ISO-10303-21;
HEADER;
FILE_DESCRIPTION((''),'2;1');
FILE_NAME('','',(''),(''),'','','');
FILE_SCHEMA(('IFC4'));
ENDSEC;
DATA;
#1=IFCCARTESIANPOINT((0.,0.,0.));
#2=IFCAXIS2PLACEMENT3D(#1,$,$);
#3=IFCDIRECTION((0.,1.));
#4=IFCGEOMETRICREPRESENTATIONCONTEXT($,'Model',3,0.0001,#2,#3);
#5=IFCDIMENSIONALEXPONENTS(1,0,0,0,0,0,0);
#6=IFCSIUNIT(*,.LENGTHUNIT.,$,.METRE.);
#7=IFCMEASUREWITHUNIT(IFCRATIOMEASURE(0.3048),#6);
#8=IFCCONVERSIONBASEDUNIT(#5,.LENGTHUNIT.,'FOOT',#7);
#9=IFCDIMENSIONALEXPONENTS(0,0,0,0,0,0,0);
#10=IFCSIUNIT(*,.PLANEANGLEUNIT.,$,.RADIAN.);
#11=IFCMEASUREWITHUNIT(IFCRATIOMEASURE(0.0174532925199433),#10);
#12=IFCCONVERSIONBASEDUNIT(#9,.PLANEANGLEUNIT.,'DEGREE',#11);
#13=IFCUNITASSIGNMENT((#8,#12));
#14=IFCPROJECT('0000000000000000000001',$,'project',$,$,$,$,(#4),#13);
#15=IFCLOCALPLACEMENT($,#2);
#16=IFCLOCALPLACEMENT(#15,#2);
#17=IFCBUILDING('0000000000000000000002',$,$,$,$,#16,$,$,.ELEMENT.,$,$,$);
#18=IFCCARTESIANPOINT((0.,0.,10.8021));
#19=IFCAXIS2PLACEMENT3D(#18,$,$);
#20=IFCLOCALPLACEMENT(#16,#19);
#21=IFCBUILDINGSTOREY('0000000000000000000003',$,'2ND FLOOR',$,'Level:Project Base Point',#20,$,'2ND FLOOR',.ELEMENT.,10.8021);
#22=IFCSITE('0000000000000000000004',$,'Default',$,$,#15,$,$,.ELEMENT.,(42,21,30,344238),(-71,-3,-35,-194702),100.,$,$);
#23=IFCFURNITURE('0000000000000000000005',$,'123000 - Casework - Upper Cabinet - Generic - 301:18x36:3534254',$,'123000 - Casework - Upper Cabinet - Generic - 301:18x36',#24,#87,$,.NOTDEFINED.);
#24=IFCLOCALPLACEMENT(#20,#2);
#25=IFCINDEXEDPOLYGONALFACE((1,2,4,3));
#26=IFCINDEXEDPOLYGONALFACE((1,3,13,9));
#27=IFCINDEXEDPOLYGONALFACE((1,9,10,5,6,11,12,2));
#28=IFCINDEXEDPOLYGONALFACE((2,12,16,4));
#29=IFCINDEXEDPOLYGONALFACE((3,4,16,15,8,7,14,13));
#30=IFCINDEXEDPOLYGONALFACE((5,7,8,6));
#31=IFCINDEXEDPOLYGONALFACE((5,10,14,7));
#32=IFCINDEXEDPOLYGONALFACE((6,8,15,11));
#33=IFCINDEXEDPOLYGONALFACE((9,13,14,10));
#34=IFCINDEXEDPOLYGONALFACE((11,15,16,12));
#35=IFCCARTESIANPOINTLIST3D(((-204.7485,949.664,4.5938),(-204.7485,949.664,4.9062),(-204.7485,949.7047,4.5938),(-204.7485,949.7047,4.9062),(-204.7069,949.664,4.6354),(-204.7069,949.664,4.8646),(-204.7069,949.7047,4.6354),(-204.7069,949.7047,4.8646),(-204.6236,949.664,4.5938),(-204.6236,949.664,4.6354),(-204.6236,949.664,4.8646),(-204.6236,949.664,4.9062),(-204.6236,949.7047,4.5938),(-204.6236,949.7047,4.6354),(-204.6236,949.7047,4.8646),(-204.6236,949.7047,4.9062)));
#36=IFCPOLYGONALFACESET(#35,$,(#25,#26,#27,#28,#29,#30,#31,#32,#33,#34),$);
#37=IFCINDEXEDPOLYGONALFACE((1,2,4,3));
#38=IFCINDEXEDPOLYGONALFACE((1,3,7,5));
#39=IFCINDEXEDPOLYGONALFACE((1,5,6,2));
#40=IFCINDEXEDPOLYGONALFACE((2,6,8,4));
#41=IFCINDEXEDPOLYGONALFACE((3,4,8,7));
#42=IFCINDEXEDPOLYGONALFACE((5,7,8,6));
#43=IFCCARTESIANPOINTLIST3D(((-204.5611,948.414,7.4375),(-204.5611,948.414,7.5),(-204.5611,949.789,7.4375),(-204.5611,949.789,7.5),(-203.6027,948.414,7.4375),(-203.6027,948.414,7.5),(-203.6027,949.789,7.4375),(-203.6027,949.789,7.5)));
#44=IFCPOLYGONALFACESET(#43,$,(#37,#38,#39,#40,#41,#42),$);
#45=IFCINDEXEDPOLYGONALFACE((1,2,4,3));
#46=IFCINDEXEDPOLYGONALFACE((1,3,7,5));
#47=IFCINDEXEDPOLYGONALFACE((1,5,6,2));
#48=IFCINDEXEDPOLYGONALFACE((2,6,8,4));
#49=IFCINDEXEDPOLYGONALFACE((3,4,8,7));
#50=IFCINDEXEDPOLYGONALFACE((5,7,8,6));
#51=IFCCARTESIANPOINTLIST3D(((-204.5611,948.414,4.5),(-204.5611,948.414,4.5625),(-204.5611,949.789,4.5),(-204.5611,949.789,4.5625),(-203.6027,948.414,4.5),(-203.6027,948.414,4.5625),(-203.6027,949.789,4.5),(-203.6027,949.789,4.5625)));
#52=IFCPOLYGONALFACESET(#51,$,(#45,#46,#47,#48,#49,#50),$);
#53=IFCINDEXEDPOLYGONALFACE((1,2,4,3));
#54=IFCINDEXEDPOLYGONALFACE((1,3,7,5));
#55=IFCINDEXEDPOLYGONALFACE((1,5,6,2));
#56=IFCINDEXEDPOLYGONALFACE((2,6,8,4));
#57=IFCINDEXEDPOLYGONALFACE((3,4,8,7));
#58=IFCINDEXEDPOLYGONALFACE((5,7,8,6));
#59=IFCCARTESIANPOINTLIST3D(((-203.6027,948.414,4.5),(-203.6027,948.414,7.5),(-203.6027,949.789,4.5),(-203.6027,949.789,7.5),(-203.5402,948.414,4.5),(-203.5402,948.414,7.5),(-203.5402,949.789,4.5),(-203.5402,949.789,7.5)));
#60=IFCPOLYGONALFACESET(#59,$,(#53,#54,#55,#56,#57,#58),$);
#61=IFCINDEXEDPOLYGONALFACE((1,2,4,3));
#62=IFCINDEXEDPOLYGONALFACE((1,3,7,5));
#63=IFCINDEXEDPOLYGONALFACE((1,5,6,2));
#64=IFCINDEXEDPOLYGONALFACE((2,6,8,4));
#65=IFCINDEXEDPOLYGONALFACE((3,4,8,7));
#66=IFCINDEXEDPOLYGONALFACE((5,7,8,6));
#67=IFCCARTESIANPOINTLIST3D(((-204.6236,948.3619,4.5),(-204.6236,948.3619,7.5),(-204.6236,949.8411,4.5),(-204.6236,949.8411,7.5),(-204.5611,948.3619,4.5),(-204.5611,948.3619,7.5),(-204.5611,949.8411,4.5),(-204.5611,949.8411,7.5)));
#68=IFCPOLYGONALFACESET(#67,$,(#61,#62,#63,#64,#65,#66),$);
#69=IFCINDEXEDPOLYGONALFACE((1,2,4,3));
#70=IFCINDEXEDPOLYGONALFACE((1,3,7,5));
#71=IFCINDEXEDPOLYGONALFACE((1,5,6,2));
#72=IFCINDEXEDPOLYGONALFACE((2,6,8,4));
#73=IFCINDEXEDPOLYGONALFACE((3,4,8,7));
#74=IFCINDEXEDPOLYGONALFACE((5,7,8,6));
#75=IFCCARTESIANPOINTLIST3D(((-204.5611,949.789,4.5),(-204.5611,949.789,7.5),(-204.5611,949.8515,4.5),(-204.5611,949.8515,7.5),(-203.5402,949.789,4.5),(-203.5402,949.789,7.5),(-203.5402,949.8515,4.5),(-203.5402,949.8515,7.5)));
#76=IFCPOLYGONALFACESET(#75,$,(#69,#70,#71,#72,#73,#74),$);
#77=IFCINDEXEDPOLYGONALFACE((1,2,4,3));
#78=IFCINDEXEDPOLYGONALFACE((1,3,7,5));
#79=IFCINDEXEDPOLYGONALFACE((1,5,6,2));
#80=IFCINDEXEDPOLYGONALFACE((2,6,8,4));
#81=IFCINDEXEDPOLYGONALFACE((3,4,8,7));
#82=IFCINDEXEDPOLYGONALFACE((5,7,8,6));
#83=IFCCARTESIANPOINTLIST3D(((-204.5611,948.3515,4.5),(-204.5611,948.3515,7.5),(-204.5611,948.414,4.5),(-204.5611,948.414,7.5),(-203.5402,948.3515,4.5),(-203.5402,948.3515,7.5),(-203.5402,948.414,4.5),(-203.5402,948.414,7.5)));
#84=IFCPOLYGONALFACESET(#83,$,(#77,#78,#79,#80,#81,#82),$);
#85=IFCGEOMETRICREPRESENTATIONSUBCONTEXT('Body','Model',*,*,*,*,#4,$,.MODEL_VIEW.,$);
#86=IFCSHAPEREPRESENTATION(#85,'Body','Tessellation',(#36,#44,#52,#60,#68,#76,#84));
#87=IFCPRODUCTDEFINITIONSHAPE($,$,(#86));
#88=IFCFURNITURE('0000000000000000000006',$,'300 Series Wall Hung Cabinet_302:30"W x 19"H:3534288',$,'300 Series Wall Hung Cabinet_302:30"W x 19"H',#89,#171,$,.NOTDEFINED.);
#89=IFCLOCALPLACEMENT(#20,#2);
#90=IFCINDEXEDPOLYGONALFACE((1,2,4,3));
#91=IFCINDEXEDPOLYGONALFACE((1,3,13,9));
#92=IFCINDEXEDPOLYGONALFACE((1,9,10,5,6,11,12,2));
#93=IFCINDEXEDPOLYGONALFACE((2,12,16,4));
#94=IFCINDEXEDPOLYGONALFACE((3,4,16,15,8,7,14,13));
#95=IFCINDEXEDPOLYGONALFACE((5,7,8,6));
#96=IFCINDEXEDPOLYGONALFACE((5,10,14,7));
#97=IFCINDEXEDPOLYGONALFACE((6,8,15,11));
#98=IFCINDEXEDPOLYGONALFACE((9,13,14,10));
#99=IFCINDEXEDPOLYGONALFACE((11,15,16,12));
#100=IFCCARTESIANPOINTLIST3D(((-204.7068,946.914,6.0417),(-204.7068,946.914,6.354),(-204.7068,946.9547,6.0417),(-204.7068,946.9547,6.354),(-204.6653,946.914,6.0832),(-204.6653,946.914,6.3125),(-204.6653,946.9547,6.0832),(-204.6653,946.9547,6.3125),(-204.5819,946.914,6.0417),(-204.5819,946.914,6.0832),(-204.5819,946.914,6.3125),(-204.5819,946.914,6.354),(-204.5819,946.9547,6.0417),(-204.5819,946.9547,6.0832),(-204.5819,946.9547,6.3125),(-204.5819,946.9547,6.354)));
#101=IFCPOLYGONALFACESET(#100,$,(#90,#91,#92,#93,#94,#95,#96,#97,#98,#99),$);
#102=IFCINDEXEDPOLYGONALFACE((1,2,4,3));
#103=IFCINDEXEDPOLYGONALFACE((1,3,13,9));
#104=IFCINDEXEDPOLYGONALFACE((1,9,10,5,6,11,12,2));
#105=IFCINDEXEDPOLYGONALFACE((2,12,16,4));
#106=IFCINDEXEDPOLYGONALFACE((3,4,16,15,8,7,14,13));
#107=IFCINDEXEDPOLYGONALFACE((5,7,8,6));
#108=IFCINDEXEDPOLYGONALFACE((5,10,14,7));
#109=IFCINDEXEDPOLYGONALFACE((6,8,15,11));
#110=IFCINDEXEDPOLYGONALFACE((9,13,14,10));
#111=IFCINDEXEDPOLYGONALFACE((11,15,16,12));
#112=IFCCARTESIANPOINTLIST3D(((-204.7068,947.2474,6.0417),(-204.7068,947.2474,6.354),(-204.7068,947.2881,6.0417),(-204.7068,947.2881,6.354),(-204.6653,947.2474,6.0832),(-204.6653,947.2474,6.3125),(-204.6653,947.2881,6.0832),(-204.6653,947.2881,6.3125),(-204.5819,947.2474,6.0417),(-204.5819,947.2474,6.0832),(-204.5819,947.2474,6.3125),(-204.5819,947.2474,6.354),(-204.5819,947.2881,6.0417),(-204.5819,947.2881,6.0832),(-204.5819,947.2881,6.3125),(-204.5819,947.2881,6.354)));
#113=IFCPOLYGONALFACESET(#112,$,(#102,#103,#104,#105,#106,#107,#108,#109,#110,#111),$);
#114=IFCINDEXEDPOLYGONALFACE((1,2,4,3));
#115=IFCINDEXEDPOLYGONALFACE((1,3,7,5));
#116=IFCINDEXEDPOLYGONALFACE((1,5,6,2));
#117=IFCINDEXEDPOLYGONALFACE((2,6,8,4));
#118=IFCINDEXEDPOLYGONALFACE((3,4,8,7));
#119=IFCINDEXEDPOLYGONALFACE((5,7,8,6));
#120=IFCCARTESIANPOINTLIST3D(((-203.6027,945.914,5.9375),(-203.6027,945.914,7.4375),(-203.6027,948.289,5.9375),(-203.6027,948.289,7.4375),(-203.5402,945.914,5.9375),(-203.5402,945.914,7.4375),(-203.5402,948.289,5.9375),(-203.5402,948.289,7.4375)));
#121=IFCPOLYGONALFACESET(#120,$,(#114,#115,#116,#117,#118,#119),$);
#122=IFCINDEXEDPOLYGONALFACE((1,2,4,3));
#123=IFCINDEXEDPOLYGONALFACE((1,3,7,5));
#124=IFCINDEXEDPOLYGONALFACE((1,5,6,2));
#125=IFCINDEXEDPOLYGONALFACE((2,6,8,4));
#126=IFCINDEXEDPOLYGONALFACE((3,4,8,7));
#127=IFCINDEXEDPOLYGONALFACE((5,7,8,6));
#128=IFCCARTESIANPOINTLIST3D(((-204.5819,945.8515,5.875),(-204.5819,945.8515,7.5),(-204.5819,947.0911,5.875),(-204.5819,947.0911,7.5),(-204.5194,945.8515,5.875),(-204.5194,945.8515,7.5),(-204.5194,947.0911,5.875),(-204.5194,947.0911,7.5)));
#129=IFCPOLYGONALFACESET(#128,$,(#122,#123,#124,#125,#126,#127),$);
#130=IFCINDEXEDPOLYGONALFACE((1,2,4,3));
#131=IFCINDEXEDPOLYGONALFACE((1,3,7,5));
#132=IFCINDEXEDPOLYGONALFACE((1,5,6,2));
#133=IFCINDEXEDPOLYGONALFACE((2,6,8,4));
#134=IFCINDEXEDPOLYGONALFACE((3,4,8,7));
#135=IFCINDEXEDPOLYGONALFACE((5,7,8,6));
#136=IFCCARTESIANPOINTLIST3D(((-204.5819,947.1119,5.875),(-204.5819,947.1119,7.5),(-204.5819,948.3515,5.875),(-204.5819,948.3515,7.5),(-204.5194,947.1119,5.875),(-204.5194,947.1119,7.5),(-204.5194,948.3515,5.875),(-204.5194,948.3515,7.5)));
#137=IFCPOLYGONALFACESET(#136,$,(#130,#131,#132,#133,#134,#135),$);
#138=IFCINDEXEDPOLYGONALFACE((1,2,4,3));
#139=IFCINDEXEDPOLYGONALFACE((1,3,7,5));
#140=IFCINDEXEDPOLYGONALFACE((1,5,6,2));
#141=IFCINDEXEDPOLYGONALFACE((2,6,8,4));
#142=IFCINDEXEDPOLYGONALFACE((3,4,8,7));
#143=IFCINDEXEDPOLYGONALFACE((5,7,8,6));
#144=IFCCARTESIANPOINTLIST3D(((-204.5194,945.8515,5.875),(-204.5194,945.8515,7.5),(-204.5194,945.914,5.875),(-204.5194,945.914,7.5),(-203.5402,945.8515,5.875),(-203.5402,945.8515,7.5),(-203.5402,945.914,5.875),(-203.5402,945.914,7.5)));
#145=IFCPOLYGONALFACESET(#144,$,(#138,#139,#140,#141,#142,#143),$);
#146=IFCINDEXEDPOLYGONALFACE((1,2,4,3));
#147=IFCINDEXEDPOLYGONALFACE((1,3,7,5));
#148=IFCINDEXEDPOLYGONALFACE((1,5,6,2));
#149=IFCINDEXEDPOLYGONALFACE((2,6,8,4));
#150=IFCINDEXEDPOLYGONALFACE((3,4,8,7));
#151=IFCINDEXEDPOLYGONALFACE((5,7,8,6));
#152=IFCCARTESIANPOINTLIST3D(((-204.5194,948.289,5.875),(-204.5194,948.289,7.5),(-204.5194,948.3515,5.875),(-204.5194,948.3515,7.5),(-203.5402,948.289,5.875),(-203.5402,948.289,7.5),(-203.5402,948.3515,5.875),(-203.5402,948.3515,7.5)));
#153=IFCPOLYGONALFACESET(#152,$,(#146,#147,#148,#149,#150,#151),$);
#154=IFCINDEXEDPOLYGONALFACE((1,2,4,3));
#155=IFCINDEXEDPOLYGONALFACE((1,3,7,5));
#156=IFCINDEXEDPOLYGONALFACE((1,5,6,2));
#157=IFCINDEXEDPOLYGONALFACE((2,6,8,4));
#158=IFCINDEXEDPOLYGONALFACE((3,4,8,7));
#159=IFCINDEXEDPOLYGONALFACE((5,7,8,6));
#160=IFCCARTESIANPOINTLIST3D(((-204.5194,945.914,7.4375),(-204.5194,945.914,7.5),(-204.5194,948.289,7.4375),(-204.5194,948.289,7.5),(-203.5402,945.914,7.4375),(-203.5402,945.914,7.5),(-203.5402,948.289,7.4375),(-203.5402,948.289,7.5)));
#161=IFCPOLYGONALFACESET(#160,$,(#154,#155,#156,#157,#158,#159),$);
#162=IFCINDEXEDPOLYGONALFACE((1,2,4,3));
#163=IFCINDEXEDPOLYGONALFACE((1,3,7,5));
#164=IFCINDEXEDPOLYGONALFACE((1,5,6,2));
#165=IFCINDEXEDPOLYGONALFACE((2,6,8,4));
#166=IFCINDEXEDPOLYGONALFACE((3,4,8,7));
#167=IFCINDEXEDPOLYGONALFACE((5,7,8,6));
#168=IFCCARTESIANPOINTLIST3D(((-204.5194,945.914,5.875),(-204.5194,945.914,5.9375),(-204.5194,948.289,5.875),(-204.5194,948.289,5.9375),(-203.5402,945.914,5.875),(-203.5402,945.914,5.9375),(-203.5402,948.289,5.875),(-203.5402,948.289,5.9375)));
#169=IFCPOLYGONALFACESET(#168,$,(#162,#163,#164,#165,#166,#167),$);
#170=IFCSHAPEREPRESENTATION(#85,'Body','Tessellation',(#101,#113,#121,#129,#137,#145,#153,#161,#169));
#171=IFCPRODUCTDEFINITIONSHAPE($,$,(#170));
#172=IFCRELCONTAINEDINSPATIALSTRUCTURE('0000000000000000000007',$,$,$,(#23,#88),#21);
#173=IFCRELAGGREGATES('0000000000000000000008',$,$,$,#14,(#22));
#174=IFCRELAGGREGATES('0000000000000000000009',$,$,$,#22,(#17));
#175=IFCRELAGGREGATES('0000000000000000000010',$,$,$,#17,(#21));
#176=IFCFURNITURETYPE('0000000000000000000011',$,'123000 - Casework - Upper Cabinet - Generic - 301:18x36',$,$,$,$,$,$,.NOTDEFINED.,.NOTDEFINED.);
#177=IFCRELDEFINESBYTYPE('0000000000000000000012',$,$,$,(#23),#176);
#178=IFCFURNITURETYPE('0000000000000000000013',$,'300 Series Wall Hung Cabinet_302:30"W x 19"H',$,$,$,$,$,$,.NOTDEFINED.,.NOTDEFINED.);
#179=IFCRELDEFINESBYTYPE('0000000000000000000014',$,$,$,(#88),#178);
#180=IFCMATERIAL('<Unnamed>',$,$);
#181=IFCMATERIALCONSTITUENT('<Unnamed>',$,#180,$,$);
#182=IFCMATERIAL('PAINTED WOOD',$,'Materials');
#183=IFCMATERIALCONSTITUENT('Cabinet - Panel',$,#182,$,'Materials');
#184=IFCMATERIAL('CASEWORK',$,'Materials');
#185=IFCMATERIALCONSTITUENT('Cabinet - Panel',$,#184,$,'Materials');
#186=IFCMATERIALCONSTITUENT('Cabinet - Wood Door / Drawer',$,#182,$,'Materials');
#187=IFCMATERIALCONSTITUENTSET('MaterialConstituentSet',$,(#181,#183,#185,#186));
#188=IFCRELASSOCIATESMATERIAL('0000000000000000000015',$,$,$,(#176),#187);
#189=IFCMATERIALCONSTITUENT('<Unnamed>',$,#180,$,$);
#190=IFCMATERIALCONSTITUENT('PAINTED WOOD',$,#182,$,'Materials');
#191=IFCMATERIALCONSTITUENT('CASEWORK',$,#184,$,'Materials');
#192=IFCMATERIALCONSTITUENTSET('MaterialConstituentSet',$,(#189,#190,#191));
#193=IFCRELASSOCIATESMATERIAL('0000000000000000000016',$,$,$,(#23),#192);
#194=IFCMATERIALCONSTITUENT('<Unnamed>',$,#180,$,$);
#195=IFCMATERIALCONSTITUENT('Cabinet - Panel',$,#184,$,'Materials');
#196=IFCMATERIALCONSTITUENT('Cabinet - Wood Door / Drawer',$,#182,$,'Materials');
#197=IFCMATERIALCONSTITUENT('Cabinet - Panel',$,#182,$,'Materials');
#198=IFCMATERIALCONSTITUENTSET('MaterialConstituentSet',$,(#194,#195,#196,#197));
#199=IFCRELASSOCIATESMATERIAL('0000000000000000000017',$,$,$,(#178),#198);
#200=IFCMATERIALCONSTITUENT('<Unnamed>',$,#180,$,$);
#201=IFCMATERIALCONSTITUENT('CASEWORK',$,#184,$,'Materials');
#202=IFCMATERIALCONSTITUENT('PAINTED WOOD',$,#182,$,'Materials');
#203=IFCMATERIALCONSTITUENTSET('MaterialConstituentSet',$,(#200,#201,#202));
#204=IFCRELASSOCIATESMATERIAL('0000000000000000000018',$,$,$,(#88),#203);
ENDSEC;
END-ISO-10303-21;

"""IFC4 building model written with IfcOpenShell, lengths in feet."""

from ifc_helpers import new_model, entity, si_unit, converted_unit, direction, frame, frame_2d, origin, origin_2d_with_axis, place, context, subcontext, project, spatial, polyline, rectangle, outline, extrude, source, transform, mapped, material, constituent, constituent_set, type_object, type_shapes, element, save


model = new_model("IFC4")

# Units and contexts
model_context = context("Model", 3, precision=0.0001, world=origin(), true_north=direction((0.0, 1.0)))
body_context = subcontext(model_context, "Body", "Model", "MODEL_VIEW")
ifc_project = project(units=[converted_unit("LENGTHUNIT", "FOOT", entity("IfcRatioMeasure", 0.3048), si_unit("LENGTHUNIT", "METRE"), dimensions=[1, 0, 0, 0, 0, 0, 0]), converted_unit("PLANEANGLEUNIT", "DEGREE", entity("IfcRatioMeasure", 0.0174532925199433), si_unit("PLANEANGLEUNIT", "RADIAN"), dimensions=[0, 0, 0, 0, 0, 0, 0])], contexts=[model_context])

# Site, building, storey
site_placement = place(None, origin())
site = spatial("IfcSite", under=ifc_project, at=site_placement, Name="Default", CompositionType="ELEMENT", RefLatitude=(42, 21, 30, 344238), RefLongitude=(-71, -3, -35, -194702), RefElevation=100.0)
building_placement = place(site_placement, origin())
building = spatial("IfcBuilding", under=site, at=building_placement, CompositionType="ELEMENT")
storey_placement = place(building_placement, frame((0.0, 0.0, 10.8021)))
storey = spatial("IfcBuildingStorey", under=building, at=storey_placement, Name="2ND FLOOR", ObjectType="Level:Project Base Point", LongName="2ND FLOOR", CompositionType="ELEMENT", Elevation=10.8021)

# Furniture
ifc_material_1 = material(Name="CASEWORK", Category="Materials")
ifc_material_2 = material(Name="<Unnamed>")
ifc_material_3 = material(Name="PAINTED WOOD", Category="Materials")
ifc_constituent_1 = constituent(ifc_material_2, Name="<Unnamed>")
ifc_constituent_2 = constituent(ifc_material_3, Name="PAINTED WOOD", Category="Materials")
ifc_constituent_3 = constituent(ifc_material_1, Name="CASEWORK", Category="Materials")
ifc_constituent_set_1 = constituent_set(constituents=[ifc_constituent_1, ifc_constituent_2, ifc_constituent_3], Name="MaterialConstituentSet")
ifc_constituent_4 = constituent(ifc_material_2, Name="<Unnamed>")
ifc_constituent_5 = constituent(ifc_material_3, Name="Cabinet - Panel", Category="Materials")
ifc_constituent_6 = constituent(ifc_material_1, Name="Cabinet - Panel", Category="Materials")
ifc_constituent_7 = constituent(ifc_material_3, Name="Cabinet - Wood Door / Drawer", Category="Materials")
ifc_constituent_set_2 = constituent_set(constituents=[ifc_constituent_4, ifc_constituent_5, ifc_constituent_6, ifc_constituent_7], Name="MaterialConstituentSet")
furniture_type_1 = type_object("IfcFurnitureType", Name="123000 - Casework - Upper Cabinet - Generic - 301:18x36", AssemblyPlace="NOTDEFINED", PredefinedType="NOTDEFINED", material=ifc_constituent_set_2)
shared_shape_1 = source(origin(), body_context, "Body", "SweptSolid", [
    extrude(outline(polyline([(0.1146, -0.0521), (0.1562, -0.0521), (0.1562, 0.0729), (-0.1562, 0.0729), (-0.1562, -0.0521), (-0.1146, -0.0521), (-0.1146, 0.0313), (0.1146, 0.0313), (0.1146, -0.0521)])), frame((0.1468, 0.0729, 0.25), z_axis=(1.0, 0.0, 0.0), x_axis=(0.0, 0.0, 1.0)), (0.0, 0.0, 1.0), 0.0407),
    extrude(rectangle(XDim=1.375, YDim=0.9583, at=frame_2d((0.0, 0.0), x_axis=(1.0, 0.0))), frame((0.75, 0.6666, 2.9375), z_axis=(0.0, 0.0, 1.0), x_axis=(-1.0, 0.0, 0.0)), (0.0, 0.0, 1.0), 0.0625),
    extrude(rectangle(XDim=1.375, YDim=0.9583, at=frame_2d((0.0, 0.0), x_axis=(1.0, 0.0))), frame((0.75, 0.6666, 0.0), z_axis=(0.0, 0.0, 1.0), x_axis=(-1.0, 0.0, 0.0)), (0.0, 0.0, 1.0), 0.0625),
    extrude(rectangle(XDim=0.0625, YDim=1.375, at=origin_2d_with_axis()), frame((0.75, 1.177, 0.0), z_axis=(0.0, 0.0, 1.0), x_axis=(0.0, 1.0, 0.0)), (0.0, 0.0, 1.0), 3.0),
    extrude(rectangle(XDim=0.0625, YDim=1.4792, at=origin_2d_with_axis()), frame((0.75, 0.1562, 0.0), z_axis=(0.0, 0.0, 1.0), x_axis=(0.0, -1.0, 0.0)), (0.0, 0.0, 1.0), 3.0),
    extrude(rectangle(XDim=0.0625, YDim=1.0208, at=origin_2d_with_axis()), frame((0.0312, 0.6979, 0.0), z_axis=(0.0, 0.0, 1.0), x_axis=(-1.0, 0.0, 0.0)), (0.0, 0.0, 1.0), 3.0),
    extrude(rectangle(XDim=0.0625, YDim=1.0208, at=origin_2d_with_axis()), frame((1.4688, 0.6979, 0.0), z_axis=(0.0, 0.0, 1.0), x_axis=(-1.0, 0.0, 0.0)), (0.0, 0.0, 1.0), 3.0),
])
type_shapes(furniture_type_1, [shared_shape_1])
furniture_1_placement = place(storey_placement, frame((-204.7485, 949.8515, 4.5), z_axis=(0.0, 0.0, 1.0), x_axis=(0.0, -1.0, 0.0)))
element("IfcFurniture", 1, at=furniture_1_placement, inside=storey, type_object=furniture_type_1, material=ifc_constituent_set_1, Name="123000 - Casework - Upper Cabinet - Generic - 301:18x36:3534254", ObjectType="123000 - Casework - Upper Cabinet - Generic - 301:18x36", PredefinedType="NOTDEFINED", context=body_context, shape_type="MappedRepresentation", body=[
    mapped(shared_shape_1, transform((0.0, 0.0, 0.0), scale=1.0)),
])
ifc_constituent_8 = constituent(ifc_material_2, Name="<Unnamed>")
ifc_constituent_9 = constituent(ifc_material_1, Name="CASEWORK", Category="Materials")
ifc_constituent_10 = constituent(ifc_material_3, Name="PAINTED WOOD", Category="Materials")
ifc_constituent_set_3 = constituent_set(constituents=[ifc_constituent_8, ifc_constituent_9, ifc_constituent_10], Name="MaterialConstituentSet")
ifc_constituent_11 = constituent(ifc_material_2, Name="<Unnamed>")
ifc_constituent_12 = constituent(ifc_material_1, Name="Cabinet - Panel", Category="Materials")
ifc_constituent_13 = constituent(ifc_material_3, Name="Cabinet - Wood Door / Drawer", Category="Materials")
ifc_constituent_14 = constituent(ifc_material_3, Name="Cabinet - Panel", Category="Materials")
ifc_constituent_set_4 = constituent_set(constituents=[ifc_constituent_11, ifc_constituent_12, ifc_constituent_13, ifc_constituent_14], Name="MaterialConstituentSet")
furniture_type_2 = type_object("IfcFurnitureType", Name="300 Series Wall Hung Cabinet_302:30\"W x 19\"H", AssemblyPlace="NOTDEFINED", PredefinedType="NOTDEFINED", material=ifc_constituent_set_4)
shared_shape_2 = source(origin(), body_context, "Body", "SweptSolid", [
    extrude(outline(polyline([(-0.0521, -0.1146), (-0.0521, -0.1562), (0.0729, -0.1562), (0.0729, 0.1562), (-0.0521, 0.1562), (-0.0521, 0.1146), (0.0313, 0.1146), (0.0313, -0.1146), (-0.0521, -0.1146)])), frame((1.0625, 1.0937, 0.3229), z_axis=(-1.0, 0.0, 0.0), x_axis=(0.0, 1.0, 0.0)), (0.0, 0.0, -1.0), 0.0407),
    extrude(outline(polyline([(-0.0521, -0.1146), (-0.0521, -0.1562), (0.0729, -0.1562), (0.0729, 0.1562), (-0.0521, 0.1562), (-0.0521, 0.1146), (0.0313, 0.1146), (0.0313, -0.1146), (-0.0521, -0.1146)])), frame((1.3958, 1.0937, 0.3229), z_axis=(-1.0, 0.0, 0.0), x_axis=(0.0, 1.0, 0.0)), (0.0, 0.0, -1.0), 0.0407),
    extrude(rectangle(XDim=0.0625, YDim=2.375, at=frame_2d((0.0, 0.0), x_axis=(1.0, 0.0))), frame((1.25, 0.0313, 0.0625), z_axis=(0.0, 0.0, 1.0), x_axis=(0.0, 1.0, 0.0)), (0.0, 0.0, 1.0), 1.5),
    extrude(rectangle(XDim=0.0625, YDim=1.2396, at=origin_2d_with_axis()), frame((0.6198, 1.0104, 0.0), z_axis=(0.0, 0.0, 1.0), x_axis=(0.0, 1.0, 0.0)), (0.0, 0.0, 1.0), 1.625),
    extrude(rectangle(XDim=0.0625, YDim=1.2396, at=frame_2d((0.0, 0.0), x_axis=(1.0, 0.0))), frame((1.8802, 1.0104, 0.0), z_axis=(0.0, 0.0, 1.0), x_axis=(0.0, 1.0, 0.0)), (0.0, 0.0, 1.0), 1.625),
    extrude(rectangle(XDim=0.0625, YDim=0.9792, at=frame_2d((0.0, 0.0), x_axis=(1.0, 0.0))), frame((0.0313, 0.4896, 0.0)), (0.0, 0.0, 1.0), 1.625),
    extrude(rectangle(XDim=0.0625, YDim=0.9792, at=frame_2d((0.0, 0.0), x_axis=(1.0, 0.0))), frame((2.4688, 0.4896, 0.0)), (0.0, 0.0, 1.0), 1.625),
    extrude(rectangle(XDim=2.375, YDim=0.9792, at=frame_2d((0.0, 0.0), x_axis=(1.0, 0.0))), frame((1.25, 0.4896, 1.5625), z_axis=(0.0, 0.0, 1.0), x_axis=(-1.0, 0.0, 0.0)), (0.0, 0.0, 1.0), 0.0625),
    extrude(rectangle(XDim=2.375, YDim=0.9792, at=frame_2d((0.0, 0.0), x_axis=(1.0, 0.0))), frame((1.25, 0.4896, 0.0), z_axis=(0.0, 0.0, 1.0), x_axis=(-1.0, 0.0, 0.0)), (0.0, 0.0, 1.0), 0.0625),
])
type_shapes(furniture_type_2, [shared_shape_2])
furniture_2_placement = place(storey_placement, frame((-203.5402, 945.8515, 5.875), z_axis=(0.0, 0.0, 1.0), x_axis=(0.0, 1.0, 0.0)))
element("IfcFurniture", 2, at=furniture_2_placement, inside=storey, type_object=furniture_type_2, material=ifc_constituent_set_3, Name="300 Series Wall Hung Cabinet_302:30\"W x 19\"H:3534288", ObjectType="300 Series Wall Hung Cabinet_302:30\"W x 19\"H", PredefinedType="NOTDEFINED", context=body_context, shape_type="MappedRepresentation", body=[
    mapped(shared_shape_2, transform((0.0, 0.0, 0.0), scale=1.0)),
])

save(model, "model.ifc")
